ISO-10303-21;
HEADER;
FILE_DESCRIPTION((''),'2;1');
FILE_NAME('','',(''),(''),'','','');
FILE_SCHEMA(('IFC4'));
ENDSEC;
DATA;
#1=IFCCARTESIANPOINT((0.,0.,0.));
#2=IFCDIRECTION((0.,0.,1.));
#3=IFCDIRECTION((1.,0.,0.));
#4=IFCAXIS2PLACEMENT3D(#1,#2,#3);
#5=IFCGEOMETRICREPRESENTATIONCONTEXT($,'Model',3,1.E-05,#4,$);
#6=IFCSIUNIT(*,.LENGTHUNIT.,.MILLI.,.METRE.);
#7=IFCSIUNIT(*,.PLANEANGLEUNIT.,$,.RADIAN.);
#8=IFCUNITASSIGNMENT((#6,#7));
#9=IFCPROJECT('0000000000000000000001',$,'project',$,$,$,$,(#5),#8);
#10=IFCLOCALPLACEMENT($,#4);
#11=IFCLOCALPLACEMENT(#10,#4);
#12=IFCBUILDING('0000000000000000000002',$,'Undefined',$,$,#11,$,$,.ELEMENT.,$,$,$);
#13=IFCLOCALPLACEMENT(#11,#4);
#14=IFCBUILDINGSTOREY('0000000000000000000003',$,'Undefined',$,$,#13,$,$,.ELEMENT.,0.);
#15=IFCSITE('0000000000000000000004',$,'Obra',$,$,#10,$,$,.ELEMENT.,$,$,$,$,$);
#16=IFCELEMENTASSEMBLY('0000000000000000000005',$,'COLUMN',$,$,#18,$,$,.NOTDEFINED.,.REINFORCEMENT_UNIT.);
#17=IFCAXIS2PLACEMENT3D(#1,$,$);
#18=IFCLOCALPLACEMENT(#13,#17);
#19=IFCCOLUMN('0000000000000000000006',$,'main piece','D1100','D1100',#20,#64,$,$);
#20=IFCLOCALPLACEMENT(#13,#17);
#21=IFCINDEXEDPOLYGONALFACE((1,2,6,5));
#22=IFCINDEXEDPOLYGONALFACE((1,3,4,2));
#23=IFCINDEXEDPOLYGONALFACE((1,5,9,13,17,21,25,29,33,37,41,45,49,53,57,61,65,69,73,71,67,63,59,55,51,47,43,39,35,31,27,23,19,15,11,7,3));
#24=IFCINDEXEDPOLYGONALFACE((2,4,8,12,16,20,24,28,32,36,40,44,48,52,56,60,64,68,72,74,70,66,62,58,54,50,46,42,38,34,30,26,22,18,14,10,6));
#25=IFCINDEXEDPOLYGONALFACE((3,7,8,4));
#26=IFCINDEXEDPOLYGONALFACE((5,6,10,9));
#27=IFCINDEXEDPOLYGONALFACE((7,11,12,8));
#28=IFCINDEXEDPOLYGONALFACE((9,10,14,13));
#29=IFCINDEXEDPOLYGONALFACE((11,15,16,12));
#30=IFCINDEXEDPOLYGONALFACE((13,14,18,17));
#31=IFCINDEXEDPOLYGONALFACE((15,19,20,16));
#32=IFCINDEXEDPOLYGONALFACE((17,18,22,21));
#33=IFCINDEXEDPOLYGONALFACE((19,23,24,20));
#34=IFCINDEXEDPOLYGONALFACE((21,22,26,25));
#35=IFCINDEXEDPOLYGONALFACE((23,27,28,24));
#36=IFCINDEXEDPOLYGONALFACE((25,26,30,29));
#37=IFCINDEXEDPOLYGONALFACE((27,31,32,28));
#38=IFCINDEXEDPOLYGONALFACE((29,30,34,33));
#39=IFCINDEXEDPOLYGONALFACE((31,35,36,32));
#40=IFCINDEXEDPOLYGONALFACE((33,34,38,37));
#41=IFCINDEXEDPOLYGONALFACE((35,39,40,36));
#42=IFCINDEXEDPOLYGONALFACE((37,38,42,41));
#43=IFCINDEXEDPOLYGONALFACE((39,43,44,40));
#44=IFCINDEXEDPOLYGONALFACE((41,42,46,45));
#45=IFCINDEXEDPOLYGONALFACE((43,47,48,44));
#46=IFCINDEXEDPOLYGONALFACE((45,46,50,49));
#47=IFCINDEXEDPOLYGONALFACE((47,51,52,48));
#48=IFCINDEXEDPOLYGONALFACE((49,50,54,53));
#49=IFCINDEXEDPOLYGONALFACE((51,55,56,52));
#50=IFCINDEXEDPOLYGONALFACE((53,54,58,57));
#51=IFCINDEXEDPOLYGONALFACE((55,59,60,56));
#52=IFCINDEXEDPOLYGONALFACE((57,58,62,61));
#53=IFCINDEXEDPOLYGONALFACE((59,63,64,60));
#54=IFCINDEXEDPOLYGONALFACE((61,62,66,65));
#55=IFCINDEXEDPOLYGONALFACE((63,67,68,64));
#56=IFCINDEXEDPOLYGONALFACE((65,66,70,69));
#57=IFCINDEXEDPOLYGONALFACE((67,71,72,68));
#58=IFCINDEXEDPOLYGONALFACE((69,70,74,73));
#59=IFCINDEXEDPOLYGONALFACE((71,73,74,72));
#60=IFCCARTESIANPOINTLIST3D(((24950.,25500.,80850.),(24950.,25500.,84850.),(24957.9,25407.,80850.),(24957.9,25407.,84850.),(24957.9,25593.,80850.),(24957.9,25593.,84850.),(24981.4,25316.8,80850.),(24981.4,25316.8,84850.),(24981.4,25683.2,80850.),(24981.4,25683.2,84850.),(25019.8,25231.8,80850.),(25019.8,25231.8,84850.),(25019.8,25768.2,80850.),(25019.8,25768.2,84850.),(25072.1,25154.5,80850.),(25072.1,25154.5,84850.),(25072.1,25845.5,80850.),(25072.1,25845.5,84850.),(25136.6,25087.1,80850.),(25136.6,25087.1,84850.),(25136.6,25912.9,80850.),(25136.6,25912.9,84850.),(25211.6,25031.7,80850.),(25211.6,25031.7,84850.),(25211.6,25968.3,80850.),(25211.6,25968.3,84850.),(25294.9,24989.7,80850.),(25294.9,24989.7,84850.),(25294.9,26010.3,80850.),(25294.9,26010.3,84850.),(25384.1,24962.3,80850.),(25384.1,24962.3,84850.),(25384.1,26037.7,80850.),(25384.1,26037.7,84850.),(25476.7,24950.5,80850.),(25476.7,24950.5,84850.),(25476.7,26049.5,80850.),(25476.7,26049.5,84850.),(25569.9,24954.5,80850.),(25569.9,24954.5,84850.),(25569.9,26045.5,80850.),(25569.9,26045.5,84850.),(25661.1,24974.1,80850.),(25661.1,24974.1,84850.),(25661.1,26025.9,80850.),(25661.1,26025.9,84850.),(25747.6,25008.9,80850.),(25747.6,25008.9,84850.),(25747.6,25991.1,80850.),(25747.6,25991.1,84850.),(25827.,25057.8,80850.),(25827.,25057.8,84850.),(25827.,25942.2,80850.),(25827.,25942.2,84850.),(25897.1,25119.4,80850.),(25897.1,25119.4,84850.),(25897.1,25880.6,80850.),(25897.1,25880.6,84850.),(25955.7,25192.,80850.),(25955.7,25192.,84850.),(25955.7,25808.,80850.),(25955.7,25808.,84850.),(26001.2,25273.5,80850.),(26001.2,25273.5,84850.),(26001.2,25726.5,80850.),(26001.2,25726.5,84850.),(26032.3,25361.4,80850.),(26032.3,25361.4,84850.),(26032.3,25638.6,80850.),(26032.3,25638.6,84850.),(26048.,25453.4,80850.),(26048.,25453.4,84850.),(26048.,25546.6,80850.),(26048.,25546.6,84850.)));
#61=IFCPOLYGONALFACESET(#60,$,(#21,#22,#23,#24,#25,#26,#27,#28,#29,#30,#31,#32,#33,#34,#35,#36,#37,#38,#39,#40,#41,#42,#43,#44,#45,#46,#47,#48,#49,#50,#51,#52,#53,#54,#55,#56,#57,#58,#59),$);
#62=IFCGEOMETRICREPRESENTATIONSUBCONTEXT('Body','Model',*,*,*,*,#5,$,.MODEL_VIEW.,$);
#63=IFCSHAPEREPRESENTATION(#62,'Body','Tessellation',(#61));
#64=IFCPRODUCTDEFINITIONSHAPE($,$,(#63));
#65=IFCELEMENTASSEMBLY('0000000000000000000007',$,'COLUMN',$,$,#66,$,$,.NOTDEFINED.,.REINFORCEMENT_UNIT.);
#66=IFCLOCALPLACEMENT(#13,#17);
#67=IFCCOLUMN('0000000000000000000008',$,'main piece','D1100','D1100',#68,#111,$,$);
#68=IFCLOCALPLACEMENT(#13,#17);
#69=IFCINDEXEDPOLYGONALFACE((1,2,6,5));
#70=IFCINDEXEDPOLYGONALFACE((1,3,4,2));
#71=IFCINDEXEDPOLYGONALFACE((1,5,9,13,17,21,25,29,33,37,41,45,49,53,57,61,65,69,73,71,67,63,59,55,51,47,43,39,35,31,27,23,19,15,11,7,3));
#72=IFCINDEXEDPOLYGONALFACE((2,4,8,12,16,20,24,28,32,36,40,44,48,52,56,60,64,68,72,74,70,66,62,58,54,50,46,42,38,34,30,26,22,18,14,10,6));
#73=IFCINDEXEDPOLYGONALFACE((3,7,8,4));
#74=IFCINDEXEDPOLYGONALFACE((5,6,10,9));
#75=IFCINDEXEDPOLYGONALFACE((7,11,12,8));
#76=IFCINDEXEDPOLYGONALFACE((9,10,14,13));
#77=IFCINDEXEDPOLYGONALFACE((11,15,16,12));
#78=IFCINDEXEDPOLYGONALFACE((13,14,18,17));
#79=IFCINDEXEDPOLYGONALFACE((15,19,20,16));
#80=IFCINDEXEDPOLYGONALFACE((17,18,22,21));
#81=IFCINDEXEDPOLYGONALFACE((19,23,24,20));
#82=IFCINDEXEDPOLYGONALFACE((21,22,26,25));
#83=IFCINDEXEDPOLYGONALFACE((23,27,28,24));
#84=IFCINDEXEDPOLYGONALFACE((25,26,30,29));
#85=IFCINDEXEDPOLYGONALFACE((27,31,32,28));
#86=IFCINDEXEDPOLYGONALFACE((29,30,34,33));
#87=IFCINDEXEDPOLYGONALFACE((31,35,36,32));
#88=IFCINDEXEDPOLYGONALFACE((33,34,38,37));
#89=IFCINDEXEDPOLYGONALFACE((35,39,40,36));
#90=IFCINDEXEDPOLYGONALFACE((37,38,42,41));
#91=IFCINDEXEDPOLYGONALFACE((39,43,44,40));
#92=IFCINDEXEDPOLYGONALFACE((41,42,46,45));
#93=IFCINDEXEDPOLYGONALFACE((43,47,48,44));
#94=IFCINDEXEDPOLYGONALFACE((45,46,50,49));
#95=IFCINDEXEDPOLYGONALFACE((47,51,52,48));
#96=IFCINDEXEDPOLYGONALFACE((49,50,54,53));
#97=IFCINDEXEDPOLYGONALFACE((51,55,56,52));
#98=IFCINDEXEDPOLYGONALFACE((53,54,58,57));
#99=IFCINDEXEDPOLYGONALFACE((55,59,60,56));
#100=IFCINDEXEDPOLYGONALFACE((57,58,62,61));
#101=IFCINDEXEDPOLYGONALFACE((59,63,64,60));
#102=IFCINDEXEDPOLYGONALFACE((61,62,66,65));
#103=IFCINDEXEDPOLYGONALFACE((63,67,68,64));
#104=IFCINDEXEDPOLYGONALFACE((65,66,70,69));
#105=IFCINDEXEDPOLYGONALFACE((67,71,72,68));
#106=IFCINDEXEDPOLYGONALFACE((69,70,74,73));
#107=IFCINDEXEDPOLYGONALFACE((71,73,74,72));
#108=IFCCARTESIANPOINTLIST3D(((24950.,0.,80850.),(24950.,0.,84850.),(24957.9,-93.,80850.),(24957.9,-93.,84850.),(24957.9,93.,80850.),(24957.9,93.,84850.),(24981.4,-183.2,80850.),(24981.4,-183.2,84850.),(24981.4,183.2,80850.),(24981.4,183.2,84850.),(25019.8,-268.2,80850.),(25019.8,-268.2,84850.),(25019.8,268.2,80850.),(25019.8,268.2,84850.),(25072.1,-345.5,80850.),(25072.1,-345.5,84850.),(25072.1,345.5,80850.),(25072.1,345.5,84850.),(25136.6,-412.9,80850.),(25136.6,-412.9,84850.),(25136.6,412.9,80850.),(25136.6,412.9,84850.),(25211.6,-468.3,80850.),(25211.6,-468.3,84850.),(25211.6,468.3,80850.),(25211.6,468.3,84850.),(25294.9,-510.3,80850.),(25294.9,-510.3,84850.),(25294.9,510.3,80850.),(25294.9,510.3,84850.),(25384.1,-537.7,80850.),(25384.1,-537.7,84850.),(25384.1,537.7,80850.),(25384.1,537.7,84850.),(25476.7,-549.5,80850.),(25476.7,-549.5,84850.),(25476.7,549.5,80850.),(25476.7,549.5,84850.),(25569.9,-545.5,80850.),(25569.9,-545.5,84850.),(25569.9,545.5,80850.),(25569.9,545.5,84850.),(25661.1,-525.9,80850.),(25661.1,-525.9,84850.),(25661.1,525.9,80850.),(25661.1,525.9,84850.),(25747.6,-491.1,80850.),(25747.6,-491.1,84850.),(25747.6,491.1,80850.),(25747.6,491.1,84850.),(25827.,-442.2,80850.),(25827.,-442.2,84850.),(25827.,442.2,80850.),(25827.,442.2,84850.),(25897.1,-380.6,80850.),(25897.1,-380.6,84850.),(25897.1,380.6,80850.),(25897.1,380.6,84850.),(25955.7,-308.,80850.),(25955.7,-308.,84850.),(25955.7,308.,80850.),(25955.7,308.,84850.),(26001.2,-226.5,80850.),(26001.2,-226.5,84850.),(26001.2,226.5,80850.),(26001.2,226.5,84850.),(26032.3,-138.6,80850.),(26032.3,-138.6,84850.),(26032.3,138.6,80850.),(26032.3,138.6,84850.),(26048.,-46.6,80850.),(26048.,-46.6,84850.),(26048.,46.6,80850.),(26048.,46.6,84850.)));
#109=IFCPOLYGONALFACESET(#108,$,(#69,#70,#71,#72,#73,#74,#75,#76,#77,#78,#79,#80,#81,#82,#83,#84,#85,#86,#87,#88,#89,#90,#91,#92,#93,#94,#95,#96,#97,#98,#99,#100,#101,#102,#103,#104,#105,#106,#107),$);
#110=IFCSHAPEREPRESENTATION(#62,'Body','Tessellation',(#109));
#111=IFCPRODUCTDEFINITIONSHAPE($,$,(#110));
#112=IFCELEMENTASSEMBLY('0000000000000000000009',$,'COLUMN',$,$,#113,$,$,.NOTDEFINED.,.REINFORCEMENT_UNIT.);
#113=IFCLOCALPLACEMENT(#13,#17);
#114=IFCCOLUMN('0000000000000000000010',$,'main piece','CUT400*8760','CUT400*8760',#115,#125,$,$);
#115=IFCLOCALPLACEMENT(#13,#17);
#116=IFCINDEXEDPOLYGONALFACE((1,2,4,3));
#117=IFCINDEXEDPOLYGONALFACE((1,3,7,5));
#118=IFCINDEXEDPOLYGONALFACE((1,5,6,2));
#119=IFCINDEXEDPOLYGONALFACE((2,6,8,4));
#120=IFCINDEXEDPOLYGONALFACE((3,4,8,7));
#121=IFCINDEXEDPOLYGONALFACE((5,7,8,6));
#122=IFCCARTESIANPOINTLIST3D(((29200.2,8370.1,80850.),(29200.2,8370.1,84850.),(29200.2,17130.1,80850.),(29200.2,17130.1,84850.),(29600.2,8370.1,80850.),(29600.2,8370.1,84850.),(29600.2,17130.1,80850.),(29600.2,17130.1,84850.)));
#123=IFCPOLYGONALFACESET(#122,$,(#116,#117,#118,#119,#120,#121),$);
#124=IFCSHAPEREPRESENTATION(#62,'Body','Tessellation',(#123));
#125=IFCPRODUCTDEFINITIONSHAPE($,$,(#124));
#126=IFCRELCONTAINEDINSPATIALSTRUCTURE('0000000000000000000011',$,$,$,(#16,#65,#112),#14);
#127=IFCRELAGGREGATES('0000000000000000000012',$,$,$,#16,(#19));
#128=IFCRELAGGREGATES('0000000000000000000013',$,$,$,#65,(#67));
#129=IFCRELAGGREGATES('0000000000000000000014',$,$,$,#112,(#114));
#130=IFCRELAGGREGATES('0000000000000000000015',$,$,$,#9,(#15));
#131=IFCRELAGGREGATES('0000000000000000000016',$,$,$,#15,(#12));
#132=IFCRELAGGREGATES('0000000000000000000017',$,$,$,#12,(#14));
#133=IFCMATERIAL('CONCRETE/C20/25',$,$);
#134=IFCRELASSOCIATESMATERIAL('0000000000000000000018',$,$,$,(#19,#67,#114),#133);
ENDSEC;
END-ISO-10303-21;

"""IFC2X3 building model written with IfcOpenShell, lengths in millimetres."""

from ifc_helpers import new_model, si_unit, frame, origin_with_axes, origin_2d_with_axis, place, context, subcontext, project, spatial, rectangle, circle, extrude, material, element, aggregate, save


model = new_model("IFC2X3")

# Units and contexts
model_context = context("Model", 3, precision=1e-05, world=origin_with_axes())
body_context = subcontext(model_context, "Body", "Model", "MODEL_VIEW")
ifc_project = project(units=[si_unit("LENGTHUNIT", "METRE", prefix="MILLI"), si_unit("PLANEANGLEUNIT", "RADIAN")], contexts=[model_context])

# Site, building, storey
site_placement = place(None, origin_with_axes())
site = spatial("IfcSite", under=ifc_project, at=site_placement, Name="Obra", CompositionType="ELEMENT")
building_placement = place(site_placement, origin_with_axes())
building = spatial("IfcBuilding", under=site, at=building_placement, Name="Undefined", CompositionType="ELEMENT")
storey_placement = place(building_placement, origin_with_axes())
storey = spatial("IfcBuildingStorey", under=building, at=storey_placement, Name="Undefined", CompositionType="ELEMENT", Elevation=0.0)

# Element assemblies, columns
assembly_1_placement = place(storey_placement, origin_with_axes())
assembly_1 = element("IfcElementAssembly", 1, at=assembly_1_placement, inside=storey, Name="COLUMN", AssemblyPlace="NOTDEFINED", PredefinedType="REINFORCEMENT_UNIT")
ifc_material_1 = material(Name="CONCRETE/C20/25")
column_1_placement = place(assembly_1_placement, frame((25500.0, 25500.0, 80850.0), z_axis=(0.0, 0.0, 1.0), x_axis=(0.0, 1.0, 0.0)))
column_1 = element("IfcColumn", 2, at=column_1_placement, material=ifc_material_1, Name="main piece", Description="D1100", ObjectType="D1100", context=body_context, shape_type="SweptSolid", body=[
    extrude(circle(Radius=550.0, at=origin_2d_with_axis()), frame((0.0, 0.0, 4000.0), z_axis=(0.0, 0.0, -1.0), x_axis=(0.0, 1.0, 0.0)), (0.0, 0.0, 1.0), 4000.0),
])
aggregate(assembly_1, [column_1])
assembly_2_placement = place(storey_placement, origin_with_axes())
assembly_2 = element("IfcElementAssembly", 3, at=assembly_2_placement, inside=storey, Name="COLUMN", AssemblyPlace="NOTDEFINED", PredefinedType="REINFORCEMENT_UNIT")
column_2_placement = place(assembly_2_placement, frame((25500.0, 0.0, 80850.0), z_axis=(0.0, 0.0, 1.0), x_axis=(0.0, 1.0, 0.0)))
column_2 = element("IfcColumn", 4, at=column_2_placement, material=ifc_material_1, Name="main piece", Description="D1100", ObjectType="D1100", context=body_context, shape_type="SweptSolid", body=[
    extrude(circle(Radius=550.0, at=origin_2d_with_axis()), frame((0.0, 0.0, 4000.0), z_axis=(0.0, 0.0, -1.0), x_axis=(0.0, 1.0, 0.0)), (0.0, 0.0, 1.0), 4000.0),
])
aggregate(assembly_2, [column_2])
assembly_3_placement = place(storey_placement, origin_with_axes())
assembly_3 = element("IfcElementAssembly", 5, at=assembly_3_placement, inside=storey, Name="COLUMN", AssemblyPlace="NOTDEFINED", PredefinedType="REINFORCEMENT_UNIT")
column_3_placement = place(assembly_3_placement, frame((29400.2, 12750.1, 80850.0), z_axis=(0.0, 0.0, 1.0), x_axis=(0.0, -1.0, 0.0)))
column_3 = element("IfcColumn", 6, at=column_3_placement, material=ifc_material_1, Name="main piece", Description="CUT400*8760", ObjectType="CUT400*8760", context=body_context, shape_type="SweptSolid", body=[
    extrude(rectangle(XDim=400.0, YDim=8760.0, at=origin_2d_with_axis()), frame((0.0, 0.0, 4000.0), z_axis=(0.0, 0.0, -1.0), x_axis=(0.0, 1.0, 0.0)), (0.0, 0.0, 1.0), 4000.0),
])
aggregate(assembly_3, [column_3])

save(model, "model.ifc")
